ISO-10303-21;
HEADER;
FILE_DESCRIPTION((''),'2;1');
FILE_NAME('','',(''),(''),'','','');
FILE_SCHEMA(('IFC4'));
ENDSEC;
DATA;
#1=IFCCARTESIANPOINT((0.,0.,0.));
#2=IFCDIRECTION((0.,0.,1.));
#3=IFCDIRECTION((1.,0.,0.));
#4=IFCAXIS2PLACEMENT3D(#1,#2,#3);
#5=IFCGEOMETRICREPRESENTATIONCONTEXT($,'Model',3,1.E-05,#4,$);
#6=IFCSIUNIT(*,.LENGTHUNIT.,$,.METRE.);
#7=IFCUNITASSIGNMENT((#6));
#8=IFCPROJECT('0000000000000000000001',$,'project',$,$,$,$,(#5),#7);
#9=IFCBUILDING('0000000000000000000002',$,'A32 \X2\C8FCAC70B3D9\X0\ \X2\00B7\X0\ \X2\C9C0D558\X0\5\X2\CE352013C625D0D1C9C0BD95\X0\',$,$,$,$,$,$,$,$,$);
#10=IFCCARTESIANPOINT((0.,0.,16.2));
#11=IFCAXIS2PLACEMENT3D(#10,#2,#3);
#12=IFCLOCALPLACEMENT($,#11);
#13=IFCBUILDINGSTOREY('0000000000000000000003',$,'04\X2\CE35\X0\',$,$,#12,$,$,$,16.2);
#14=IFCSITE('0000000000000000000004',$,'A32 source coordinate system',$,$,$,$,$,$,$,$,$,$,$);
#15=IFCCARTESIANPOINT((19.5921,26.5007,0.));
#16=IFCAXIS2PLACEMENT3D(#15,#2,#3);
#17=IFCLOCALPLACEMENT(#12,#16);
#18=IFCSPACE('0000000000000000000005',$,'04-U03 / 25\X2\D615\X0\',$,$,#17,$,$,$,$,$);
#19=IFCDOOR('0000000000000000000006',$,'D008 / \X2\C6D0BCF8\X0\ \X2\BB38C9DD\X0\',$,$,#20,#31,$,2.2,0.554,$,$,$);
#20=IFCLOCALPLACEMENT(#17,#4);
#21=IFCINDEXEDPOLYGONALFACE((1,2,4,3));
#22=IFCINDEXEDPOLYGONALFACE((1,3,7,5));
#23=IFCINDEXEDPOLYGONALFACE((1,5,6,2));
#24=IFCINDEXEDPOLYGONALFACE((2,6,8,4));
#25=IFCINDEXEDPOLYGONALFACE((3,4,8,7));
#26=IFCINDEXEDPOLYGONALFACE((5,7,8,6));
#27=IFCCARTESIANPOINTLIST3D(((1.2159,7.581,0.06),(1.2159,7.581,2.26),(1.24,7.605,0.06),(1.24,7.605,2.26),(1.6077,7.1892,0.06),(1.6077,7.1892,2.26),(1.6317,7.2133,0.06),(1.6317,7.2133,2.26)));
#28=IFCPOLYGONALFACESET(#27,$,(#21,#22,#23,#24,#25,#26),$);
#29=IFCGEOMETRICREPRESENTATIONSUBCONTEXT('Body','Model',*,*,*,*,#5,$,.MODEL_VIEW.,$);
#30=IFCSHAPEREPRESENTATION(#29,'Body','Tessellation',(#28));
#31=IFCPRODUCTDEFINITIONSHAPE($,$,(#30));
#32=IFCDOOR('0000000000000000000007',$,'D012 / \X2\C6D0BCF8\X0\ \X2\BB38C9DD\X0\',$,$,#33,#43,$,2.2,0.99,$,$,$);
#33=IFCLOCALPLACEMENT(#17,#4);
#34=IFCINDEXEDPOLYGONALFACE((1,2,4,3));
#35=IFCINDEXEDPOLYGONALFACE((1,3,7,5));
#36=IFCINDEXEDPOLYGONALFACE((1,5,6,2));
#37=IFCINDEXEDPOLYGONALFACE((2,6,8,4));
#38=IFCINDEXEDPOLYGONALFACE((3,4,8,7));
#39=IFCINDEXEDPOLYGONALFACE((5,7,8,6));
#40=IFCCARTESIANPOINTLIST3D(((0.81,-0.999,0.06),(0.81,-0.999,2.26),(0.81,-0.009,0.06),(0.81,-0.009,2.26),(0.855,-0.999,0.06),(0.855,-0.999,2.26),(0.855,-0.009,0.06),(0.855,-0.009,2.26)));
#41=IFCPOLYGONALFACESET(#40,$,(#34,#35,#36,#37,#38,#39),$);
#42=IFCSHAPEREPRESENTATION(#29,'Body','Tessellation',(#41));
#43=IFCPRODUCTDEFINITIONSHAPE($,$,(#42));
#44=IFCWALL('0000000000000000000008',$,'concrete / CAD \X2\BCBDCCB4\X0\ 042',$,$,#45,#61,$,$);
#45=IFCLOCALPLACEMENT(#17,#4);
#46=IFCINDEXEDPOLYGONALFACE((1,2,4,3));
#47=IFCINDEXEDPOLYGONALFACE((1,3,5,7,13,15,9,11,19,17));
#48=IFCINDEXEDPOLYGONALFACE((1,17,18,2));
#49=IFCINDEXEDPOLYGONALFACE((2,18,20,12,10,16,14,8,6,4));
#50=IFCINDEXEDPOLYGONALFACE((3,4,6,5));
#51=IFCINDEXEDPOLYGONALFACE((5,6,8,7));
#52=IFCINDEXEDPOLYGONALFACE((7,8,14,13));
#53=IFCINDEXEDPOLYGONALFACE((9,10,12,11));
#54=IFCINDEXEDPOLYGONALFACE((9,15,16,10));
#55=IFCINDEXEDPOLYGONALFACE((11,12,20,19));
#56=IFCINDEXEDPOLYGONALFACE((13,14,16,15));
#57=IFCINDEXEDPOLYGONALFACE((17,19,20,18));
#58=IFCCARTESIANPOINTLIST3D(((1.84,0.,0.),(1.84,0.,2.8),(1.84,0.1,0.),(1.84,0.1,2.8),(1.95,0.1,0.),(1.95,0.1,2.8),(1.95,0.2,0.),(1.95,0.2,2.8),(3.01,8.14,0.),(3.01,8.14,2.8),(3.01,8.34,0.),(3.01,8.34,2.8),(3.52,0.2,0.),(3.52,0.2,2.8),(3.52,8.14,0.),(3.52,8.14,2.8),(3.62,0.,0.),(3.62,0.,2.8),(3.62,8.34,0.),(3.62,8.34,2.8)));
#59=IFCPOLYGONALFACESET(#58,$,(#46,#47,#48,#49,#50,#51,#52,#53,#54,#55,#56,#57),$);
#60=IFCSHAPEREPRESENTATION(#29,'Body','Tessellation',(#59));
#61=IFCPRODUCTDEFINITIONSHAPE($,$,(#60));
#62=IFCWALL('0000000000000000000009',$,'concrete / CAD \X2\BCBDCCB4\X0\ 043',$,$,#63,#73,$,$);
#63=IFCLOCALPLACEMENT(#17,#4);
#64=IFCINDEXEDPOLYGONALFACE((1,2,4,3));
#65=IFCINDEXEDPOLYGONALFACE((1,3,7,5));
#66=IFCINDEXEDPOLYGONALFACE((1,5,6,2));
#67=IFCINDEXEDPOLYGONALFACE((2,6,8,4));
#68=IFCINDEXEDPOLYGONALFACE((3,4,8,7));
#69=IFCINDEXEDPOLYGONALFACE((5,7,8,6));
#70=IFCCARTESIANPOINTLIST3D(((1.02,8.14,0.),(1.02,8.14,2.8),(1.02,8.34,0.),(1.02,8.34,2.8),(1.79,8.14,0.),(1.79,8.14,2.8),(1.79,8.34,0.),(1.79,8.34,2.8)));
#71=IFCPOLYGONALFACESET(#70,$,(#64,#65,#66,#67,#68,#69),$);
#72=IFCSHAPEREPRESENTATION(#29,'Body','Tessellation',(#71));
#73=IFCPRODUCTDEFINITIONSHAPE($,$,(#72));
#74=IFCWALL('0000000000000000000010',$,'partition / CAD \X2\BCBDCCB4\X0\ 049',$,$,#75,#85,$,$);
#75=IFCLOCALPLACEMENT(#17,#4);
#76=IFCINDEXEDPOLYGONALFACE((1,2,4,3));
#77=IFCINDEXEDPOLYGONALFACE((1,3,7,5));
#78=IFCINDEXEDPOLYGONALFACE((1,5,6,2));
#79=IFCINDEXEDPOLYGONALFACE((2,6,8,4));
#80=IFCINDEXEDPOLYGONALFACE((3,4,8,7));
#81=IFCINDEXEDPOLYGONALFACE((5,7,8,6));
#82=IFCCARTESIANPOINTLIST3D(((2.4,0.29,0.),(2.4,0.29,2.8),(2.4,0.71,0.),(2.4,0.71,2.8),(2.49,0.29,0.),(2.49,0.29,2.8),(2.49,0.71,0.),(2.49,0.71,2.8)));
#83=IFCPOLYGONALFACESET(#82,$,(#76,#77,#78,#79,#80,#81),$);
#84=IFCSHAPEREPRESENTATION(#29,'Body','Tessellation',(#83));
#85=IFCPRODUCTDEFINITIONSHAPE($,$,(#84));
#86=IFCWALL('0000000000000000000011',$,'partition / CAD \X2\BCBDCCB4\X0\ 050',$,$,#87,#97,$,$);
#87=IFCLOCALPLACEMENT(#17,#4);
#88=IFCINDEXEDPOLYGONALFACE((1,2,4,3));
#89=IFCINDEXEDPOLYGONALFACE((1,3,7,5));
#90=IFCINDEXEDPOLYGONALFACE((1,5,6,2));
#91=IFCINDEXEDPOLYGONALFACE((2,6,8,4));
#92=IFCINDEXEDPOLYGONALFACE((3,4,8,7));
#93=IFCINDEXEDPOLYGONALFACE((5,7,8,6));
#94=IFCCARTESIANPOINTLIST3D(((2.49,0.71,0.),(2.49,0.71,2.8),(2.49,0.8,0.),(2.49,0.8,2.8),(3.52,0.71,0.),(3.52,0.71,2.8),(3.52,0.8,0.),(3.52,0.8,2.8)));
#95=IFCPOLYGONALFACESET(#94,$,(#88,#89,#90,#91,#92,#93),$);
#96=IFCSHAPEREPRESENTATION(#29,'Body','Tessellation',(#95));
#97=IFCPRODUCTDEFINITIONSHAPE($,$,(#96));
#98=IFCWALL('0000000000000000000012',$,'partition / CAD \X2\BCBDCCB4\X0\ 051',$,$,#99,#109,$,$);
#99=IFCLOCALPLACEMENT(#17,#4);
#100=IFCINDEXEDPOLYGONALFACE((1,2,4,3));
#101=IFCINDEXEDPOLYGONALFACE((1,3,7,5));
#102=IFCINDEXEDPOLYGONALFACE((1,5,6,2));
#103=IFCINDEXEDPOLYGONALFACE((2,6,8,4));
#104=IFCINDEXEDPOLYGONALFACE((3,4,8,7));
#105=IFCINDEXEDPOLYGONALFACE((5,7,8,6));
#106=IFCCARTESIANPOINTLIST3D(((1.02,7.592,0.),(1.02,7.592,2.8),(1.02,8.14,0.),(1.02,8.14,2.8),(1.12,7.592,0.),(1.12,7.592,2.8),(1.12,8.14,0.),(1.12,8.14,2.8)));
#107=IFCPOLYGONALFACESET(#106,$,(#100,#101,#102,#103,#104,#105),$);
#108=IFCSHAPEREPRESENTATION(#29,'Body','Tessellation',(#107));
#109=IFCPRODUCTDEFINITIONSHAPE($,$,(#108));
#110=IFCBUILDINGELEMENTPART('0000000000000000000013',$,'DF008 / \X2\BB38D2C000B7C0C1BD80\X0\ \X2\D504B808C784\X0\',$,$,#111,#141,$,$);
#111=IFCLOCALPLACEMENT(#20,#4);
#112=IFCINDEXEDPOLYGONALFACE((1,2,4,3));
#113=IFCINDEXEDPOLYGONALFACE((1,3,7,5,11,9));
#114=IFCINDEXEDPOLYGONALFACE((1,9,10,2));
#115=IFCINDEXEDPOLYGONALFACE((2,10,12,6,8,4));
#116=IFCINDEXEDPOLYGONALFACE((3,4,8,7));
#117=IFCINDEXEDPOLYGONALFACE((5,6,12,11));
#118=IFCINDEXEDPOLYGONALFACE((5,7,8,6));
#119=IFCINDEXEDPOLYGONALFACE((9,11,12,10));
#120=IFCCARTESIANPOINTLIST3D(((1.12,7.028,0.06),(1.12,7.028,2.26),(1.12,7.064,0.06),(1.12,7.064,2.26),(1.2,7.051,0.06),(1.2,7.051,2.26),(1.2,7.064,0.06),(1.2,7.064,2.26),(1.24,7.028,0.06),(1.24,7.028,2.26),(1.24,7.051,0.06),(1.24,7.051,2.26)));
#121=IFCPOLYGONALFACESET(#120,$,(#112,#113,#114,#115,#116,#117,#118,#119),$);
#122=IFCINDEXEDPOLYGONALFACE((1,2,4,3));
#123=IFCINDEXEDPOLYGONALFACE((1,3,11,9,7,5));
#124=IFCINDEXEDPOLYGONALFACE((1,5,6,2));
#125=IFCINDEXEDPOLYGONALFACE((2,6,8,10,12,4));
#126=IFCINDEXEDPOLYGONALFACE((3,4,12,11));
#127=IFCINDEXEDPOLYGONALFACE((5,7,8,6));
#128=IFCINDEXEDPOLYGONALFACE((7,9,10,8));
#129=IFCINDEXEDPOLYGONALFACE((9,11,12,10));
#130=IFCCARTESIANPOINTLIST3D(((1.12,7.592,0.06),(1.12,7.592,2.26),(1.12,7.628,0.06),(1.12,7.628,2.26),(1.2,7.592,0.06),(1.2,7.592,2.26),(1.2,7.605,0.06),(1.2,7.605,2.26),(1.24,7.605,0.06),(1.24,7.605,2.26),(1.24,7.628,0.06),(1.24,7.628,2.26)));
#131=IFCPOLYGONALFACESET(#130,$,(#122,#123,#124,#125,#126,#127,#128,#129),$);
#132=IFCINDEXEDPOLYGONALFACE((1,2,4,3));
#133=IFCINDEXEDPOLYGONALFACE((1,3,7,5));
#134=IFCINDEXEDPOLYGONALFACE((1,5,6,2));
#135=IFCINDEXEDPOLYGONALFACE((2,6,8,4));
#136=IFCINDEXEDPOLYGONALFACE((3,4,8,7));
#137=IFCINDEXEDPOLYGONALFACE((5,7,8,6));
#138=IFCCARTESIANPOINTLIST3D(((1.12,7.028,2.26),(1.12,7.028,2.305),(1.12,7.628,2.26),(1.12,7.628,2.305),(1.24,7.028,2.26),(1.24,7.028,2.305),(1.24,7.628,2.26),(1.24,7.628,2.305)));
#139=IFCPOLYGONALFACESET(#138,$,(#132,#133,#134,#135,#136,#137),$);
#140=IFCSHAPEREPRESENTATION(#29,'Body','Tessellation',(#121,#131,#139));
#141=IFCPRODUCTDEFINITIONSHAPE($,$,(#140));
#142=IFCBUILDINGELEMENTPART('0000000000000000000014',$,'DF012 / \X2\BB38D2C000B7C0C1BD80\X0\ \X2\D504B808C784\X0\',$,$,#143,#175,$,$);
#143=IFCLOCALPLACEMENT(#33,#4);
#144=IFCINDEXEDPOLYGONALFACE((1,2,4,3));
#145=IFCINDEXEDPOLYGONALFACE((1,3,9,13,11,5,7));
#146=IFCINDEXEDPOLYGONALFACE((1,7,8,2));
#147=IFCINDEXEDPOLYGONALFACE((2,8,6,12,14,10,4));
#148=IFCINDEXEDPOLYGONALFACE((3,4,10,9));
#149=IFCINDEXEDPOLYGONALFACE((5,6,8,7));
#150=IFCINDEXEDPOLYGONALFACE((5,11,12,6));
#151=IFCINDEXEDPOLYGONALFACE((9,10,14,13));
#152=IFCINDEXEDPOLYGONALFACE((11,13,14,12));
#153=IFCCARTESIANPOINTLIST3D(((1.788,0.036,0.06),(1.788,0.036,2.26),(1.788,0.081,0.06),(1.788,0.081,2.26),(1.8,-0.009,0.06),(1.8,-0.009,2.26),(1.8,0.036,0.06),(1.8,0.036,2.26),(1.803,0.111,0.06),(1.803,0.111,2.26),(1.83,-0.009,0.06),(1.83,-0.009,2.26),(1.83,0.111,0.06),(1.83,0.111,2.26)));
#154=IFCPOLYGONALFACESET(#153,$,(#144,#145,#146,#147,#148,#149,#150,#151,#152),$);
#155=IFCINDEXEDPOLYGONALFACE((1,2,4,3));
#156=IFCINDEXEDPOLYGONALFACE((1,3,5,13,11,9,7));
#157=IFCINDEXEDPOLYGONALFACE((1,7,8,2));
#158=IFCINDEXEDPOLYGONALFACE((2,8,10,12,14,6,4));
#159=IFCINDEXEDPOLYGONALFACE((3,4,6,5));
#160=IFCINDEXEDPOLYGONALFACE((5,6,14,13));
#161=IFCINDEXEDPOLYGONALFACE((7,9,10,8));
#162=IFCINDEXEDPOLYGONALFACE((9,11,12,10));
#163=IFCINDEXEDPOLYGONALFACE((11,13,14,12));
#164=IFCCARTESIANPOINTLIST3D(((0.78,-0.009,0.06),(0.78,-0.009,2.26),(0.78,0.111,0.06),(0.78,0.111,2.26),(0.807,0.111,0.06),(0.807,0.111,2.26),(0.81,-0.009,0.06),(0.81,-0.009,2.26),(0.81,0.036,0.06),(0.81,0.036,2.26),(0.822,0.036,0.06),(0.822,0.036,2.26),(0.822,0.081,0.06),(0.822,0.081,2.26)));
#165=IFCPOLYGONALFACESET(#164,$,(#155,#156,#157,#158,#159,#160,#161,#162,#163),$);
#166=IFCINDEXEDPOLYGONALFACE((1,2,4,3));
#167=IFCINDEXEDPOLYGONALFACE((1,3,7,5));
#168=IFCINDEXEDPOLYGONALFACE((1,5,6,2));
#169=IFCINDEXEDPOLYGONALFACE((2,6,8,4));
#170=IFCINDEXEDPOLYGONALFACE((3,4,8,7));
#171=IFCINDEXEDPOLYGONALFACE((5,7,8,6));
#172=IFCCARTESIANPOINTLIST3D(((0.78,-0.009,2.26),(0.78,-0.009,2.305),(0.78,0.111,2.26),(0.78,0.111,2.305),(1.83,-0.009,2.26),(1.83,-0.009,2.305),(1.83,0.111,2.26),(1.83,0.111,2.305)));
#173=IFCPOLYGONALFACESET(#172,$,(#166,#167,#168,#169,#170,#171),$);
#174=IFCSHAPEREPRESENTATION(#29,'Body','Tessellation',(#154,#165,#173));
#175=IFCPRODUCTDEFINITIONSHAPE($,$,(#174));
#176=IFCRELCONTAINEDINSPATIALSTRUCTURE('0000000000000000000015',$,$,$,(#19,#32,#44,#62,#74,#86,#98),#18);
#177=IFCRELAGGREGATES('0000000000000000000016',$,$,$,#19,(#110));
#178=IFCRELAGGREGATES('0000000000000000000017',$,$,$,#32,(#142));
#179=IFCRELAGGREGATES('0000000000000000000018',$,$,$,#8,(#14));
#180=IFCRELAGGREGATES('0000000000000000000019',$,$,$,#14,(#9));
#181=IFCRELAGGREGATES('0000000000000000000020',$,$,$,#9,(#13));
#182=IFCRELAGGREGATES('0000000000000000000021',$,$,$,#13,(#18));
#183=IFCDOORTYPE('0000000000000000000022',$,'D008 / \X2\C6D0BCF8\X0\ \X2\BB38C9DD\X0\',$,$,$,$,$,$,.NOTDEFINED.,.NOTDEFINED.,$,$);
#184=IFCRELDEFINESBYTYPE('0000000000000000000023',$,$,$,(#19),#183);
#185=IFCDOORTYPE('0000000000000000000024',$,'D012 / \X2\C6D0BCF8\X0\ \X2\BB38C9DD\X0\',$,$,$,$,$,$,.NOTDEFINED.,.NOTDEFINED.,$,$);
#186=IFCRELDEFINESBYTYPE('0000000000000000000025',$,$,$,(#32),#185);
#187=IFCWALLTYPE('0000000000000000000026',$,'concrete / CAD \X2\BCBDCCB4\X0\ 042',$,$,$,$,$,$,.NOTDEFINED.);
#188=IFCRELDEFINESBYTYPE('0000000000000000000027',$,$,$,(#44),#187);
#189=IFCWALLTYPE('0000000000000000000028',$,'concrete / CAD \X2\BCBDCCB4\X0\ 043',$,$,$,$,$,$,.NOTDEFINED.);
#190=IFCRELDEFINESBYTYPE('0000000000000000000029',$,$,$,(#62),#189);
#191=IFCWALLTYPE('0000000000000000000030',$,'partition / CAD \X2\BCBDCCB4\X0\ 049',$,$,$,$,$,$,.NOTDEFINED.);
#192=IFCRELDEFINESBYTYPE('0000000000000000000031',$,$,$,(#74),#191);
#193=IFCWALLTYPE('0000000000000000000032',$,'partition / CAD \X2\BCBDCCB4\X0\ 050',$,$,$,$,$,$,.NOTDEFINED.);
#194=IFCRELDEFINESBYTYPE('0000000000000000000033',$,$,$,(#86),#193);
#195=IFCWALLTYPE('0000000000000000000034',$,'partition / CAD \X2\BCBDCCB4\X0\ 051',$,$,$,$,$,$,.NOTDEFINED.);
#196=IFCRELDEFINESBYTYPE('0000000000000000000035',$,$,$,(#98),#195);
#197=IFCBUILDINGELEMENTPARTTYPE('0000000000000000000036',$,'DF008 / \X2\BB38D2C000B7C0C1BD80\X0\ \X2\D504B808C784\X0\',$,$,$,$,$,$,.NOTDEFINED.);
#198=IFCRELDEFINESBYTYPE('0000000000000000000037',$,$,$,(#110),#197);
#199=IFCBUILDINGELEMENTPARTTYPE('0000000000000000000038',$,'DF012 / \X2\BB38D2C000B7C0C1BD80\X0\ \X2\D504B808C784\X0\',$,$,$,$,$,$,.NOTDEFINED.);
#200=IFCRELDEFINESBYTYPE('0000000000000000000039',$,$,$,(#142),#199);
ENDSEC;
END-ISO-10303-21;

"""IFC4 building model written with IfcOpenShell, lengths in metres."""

from ifc_helpers import new_model, si_unit, frame, origin, origin_with_axes, place, context, subcontext, project, spatial, polyline, outline, extrude, source, transform, mapped, type_object, type_shapes, element, aggregate, save


model = new_model("IFC4")

# Units and contexts
model_context = context("Model", 3, precision=1e-05, world=origin_with_axes())
body_context = subcontext(model_context, "Body", "Model", "MODEL_VIEW")
ifc_project = project(units=[si_unit("LENGTHUNIT", "METRE")], contexts=[model_context])

# Site, building, storey, space
storey_placement = place(None, frame((0.0, 0.0, 16.2), z_axis=(0.0, 0.0, 1.0), x_axis=(1.0, 0.0, 0.0)))
space_placement = place(storey_placement, frame((19.5921, 26.5007, 0.0), z_axis=(0.0, 0.0, 1.0), x_axis=(1.0, 0.0, 0.0)))
site = spatial("IfcSite", under=ifc_project, Name="A32 source coordinate system")
building = spatial("IfcBuilding", under=site, Name="A32 주거동 · 지하5층–옥탑지붕")
storey = spatial("IfcBuildingStorey", under=building, at=storey_placement, Name="04층", Elevation=16.2)
space = spatial("IfcSpace", under=storey, at=space_placement, Name="04-U03 / 25형")

# Doors
door_type_1 = type_object("IfcDoorType", Name="D008 / 원본 문짝", OperationType="NOTDEFINED", PredefinedType="NOTDEFINED")
shared_shape_1 = source(origin(), body_context, "Body", "SweptSolid", [
    extrude(outline(polyline([(1.24, 7.605), (1.6317, 7.2133), (1.6077, 7.1892), (1.2159, 7.581), (1.24, 7.605)])), frame((0.0, 0.0, 0.06)), (0.0, 0.0, 1.0), 2.2),
])
type_shapes(door_type_1, [shared_shape_1])
door_1_placement = place(space_placement, origin_with_axes())
door_1 = element("IfcDoor", 1, at=door_1_placement, inside=space, type_object=door_type_1, Name="D008 / 원본 문짝", OverallHeight=2.2, OverallWidth=0.554, context=body_context, shape_type="MappedRepresentation", body=[
    mapped(shared_shape_1, transform((0.0, 0.0, 0.0), scale=1.0)),
])
door_type_2 = type_object("IfcDoorType", Name="D012 / 원본 문짝", OperationType="NOTDEFINED", PredefinedType="NOTDEFINED")
shared_shape_2 = source(origin(), body_context, "Body", "SweptSolid", [
    extrude(outline(polyline([(0.855, -0.999), (0.81, -0.999), (0.81, -0.009), (0.855, -0.009), (0.855, -0.999)])), frame((0.0, 0.0, 0.06)), (0.0, 0.0, 1.0), 2.2),
])
type_shapes(door_type_2, [shared_shape_2])
door_2_placement = place(space_placement, origin_with_axes())
door_2 = element("IfcDoor", 2, at=door_2_placement, inside=space, type_object=door_type_2, Name="D012 / 원본 문짝", OverallHeight=2.2, OverallWidth=0.99, context=body_context, shape_type="MappedRepresentation", body=[
    mapped(shared_shape_2, transform((0.0, 0.0, 0.0), scale=1.0)),
])

# Walls
wall_type_1 = type_object("IfcWallType", Name="concrete / CAD 벽체 042", PredefinedType="NOTDEFINED")
shared_shape_3 = source(origin(), body_context, "Body", "SweptSolid", [
    extrude(outline(polyline([(3.01, 8.34), (3.97, 8.34), (3.97, 8.34), (3.62, 8.34), (3.62, 0.0), (1.84, 0.0), (1.84, 0.1), (1.95, 0.1), (1.95, 0.2), (3.52, 0.2), (3.52, 8.14), (3.01, 8.14), (3.01, 8.34)])), origin(), (0.0, 0.0, 1.0), 2.8),
])
type_shapes(wall_type_1, [shared_shape_3])
wall_1_placement = place(space_placement, origin_with_axes())
element("IfcWall", 3, at=wall_1_placement, inside=space, type_object=wall_type_1, Name="concrete / CAD 벽체 042", context=body_context, shape_type="MappedRepresentation", body=[
    mapped(shared_shape_3, transform((0.0, 0.0, 0.0), scale=1.0)),
])
wall_type_2 = type_object("IfcWallType", Name="concrete / CAD 벽체 043", PredefinedType="NOTDEFINED")
shared_shape_4 = source(origin(), body_context, "Body", "SweptSolid", [
    extrude(outline(polyline([(1.79, 8.14), (1.02, 8.14), (1.02, 8.34), (1.79, 8.34), (1.79, 8.14)])), origin(), (0.0, 0.0, 1.0), 2.8),
])
type_shapes(wall_type_2, [shared_shape_4])
wall_2_placement = place(space_placement, origin_with_axes())
element("IfcWall", 4, at=wall_2_placement, inside=space, type_object=wall_type_2, Name="concrete / CAD 벽체 043", context=body_context, shape_type="MappedRepresentation", body=[
    mapped(shared_shape_4, transform((0.0, 0.0, 0.0), scale=1.0)),
])
wall_type_3 = type_object("IfcWallType", Name="partition / CAD 벽체 049", PredefinedType="NOTDEFINED")
shared_shape_5 = source(origin(), body_context, "Body", "SweptSolid", [
    extrude(outline(polyline([(2.49, 0.29), (2.4, 0.29), (2.4, 0.71), (2.49, 0.71), (2.49, 0.29)])), origin(), (0.0, 0.0, 1.0), 2.8),
])
type_shapes(wall_type_3, [shared_shape_5])
wall_3_placement = place(space_placement, origin_with_axes())
element("IfcWall", 5, at=wall_3_placement, inside=space, type_object=wall_type_3, Name="partition / CAD 벽체 049", context=body_context, shape_type="MappedRepresentation", body=[
    mapped(shared_shape_5, transform((0.0, 0.0, 0.0), scale=1.0)),
])
wall_type_4 = type_object("IfcWallType", Name="partition / CAD 벽체 050", PredefinedType="NOTDEFINED")
shared_shape_6 = source(origin(), body_context, "Body", "SweptSolid", [
    extrude(outline(polyline([(2.49, 0.71), (2.49, 0.8), (3.52, 0.8), (3.52, 0.71), (2.49, 0.71)])), origin(), (0.0, 0.0, 1.0), 2.8),
])
type_shapes(wall_type_4, [shared_shape_6])
wall_4_placement = place(space_placement, origin_with_axes())
element("IfcWall", 6, at=wall_4_placement, inside=space, type_object=wall_type_4, Name="partition / CAD 벽체 050", context=body_context, shape_type="MappedRepresentation", body=[
    mapped(shared_shape_6, transform((0.0, 0.0, 0.0), scale=1.0)),
])
wall_type_5 = type_object("IfcWallType", Name="partition / CAD 벽체 051", PredefinedType="NOTDEFINED")
shared_shape_7 = source(origin(), body_context, "Body", "SweptSolid", [
    extrude(outline(polyline([(1.02, 8.14), (1.12, 8.14), (1.12, 7.592), (1.02, 7.592), (1.02, 8.14)])), origin(), (0.0, 0.0, 1.0), 2.8),
])
type_shapes(wall_type_5, [shared_shape_7])
wall_5_placement = place(space_placement, origin_with_axes())
element("IfcWall", 7, at=wall_5_placement, inside=space, type_object=wall_type_5, Name="partition / CAD 벽체 051", context=body_context, shape_type="MappedRepresentation", body=[
    mapped(shared_shape_7, transform((0.0, 0.0, 0.0), scale=1.0)),
])

# Building element parts
building_element_part_type_1 = type_object("IfcBuildingElementPartType", Name="DF008 / 문틀·상부 프레임", PredefinedType="NOTDEFINED")
shared_shape_8 = source(origin(), body_context, "Body", "SweptSolid", [
    extrude(outline(polyline([(1.12, 7.064), (1.2, 7.064), (1.2, 7.051), (1.24, 7.051), (1.24, 7.028), (1.12, 7.028), (1.12, 7.064)])), frame((0.0, 0.0, 0.06)), (0.0, 0.0, 1.0), 2.2),
    extrude(outline(polyline([(1.24, 7.628), (1.24, 7.605), (1.2, 7.605), (1.2, 7.592), (1.12, 7.592), (1.12, 7.628), (1.24, 7.628)])), frame((0.0, 0.0, 0.06)), (0.0, 0.0, 1.0), 2.2),
    extrude(outline(polyline([(1.12, 7.028), (1.12, 7.628), (1.24, 7.628), (1.24, 7.028), (1.12, 7.028)])), frame((0.0, 0.0, 2.26)), (0.0, 0.0, 1.0), 0.045),
])
type_shapes(building_element_part_type_1, [shared_shape_8])
building_element_part_1_placement = place(door_1_placement, origin_with_axes())
building_element_part_1 = element("IfcBuildingElementPart", 8, at=building_element_part_1_placement, type_object=building_element_part_type_1, Name="DF008 / 문틀·상부 프레임", context=body_context, shape_type="MappedRepresentation", body=[
    mapped(shared_shape_8, transform((0.0, 0.0, 0.0), scale=1.0)),
])
aggregate(door_1, [building_element_part_1])
building_element_part_type_2 = type_object("IfcBuildingElementPartType", Name="DF012 / 문틀·상부 프레임", PredefinedType="NOTDEFINED")
shared_shape_9 = source(origin(), body_context, "Body", "SweptSolid", [
    extrude(outline(polyline([(1.8, -0.009), (1.8, 0.036), (1.788, 0.036), (1.788, 0.081), (1.803, 0.111), (1.83, 0.111), (1.83, -0.009), (1.8, -0.009)])), frame((0.0, 0.0, 0.06)), (0.0, 0.0, 1.0), 2.2),
    extrude(outline(polyline([(0.78, 0.111), (0.807, 0.111), (0.822, 0.081), (0.822, 0.036), (0.81, 0.036), (0.81, -0.009), (0.78, -0.009), (0.78, 0.111)])), frame((0.0, 0.0, 0.06)), (0.0, 0.0, 1.0), 2.2),
    extrude(outline(polyline([(0.78, -0.009), (0.78, 0.111), (1.83, 0.111), (1.83, -0.009), (0.78, -0.009)])), frame((0.0, 0.0, 2.26)), (0.0, 0.0, 1.0), 0.045),
])
type_shapes(building_element_part_type_2, [shared_shape_9])
building_element_part_2_placement = place(door_2_placement, origin_with_axes())
building_element_part_2 = element("IfcBuildingElementPart", 9, at=building_element_part_2_placement, type_object=building_element_part_type_2, Name="DF012 / 문틀·상부 프레임", context=body_context, shape_type="MappedRepresentation", body=[
    mapped(shared_shape_9, transform((0.0, 0.0, 0.0), scale=1.0)),
])
aggregate(door_2, [building_element_part_2])

save(model, "model.ifc")
